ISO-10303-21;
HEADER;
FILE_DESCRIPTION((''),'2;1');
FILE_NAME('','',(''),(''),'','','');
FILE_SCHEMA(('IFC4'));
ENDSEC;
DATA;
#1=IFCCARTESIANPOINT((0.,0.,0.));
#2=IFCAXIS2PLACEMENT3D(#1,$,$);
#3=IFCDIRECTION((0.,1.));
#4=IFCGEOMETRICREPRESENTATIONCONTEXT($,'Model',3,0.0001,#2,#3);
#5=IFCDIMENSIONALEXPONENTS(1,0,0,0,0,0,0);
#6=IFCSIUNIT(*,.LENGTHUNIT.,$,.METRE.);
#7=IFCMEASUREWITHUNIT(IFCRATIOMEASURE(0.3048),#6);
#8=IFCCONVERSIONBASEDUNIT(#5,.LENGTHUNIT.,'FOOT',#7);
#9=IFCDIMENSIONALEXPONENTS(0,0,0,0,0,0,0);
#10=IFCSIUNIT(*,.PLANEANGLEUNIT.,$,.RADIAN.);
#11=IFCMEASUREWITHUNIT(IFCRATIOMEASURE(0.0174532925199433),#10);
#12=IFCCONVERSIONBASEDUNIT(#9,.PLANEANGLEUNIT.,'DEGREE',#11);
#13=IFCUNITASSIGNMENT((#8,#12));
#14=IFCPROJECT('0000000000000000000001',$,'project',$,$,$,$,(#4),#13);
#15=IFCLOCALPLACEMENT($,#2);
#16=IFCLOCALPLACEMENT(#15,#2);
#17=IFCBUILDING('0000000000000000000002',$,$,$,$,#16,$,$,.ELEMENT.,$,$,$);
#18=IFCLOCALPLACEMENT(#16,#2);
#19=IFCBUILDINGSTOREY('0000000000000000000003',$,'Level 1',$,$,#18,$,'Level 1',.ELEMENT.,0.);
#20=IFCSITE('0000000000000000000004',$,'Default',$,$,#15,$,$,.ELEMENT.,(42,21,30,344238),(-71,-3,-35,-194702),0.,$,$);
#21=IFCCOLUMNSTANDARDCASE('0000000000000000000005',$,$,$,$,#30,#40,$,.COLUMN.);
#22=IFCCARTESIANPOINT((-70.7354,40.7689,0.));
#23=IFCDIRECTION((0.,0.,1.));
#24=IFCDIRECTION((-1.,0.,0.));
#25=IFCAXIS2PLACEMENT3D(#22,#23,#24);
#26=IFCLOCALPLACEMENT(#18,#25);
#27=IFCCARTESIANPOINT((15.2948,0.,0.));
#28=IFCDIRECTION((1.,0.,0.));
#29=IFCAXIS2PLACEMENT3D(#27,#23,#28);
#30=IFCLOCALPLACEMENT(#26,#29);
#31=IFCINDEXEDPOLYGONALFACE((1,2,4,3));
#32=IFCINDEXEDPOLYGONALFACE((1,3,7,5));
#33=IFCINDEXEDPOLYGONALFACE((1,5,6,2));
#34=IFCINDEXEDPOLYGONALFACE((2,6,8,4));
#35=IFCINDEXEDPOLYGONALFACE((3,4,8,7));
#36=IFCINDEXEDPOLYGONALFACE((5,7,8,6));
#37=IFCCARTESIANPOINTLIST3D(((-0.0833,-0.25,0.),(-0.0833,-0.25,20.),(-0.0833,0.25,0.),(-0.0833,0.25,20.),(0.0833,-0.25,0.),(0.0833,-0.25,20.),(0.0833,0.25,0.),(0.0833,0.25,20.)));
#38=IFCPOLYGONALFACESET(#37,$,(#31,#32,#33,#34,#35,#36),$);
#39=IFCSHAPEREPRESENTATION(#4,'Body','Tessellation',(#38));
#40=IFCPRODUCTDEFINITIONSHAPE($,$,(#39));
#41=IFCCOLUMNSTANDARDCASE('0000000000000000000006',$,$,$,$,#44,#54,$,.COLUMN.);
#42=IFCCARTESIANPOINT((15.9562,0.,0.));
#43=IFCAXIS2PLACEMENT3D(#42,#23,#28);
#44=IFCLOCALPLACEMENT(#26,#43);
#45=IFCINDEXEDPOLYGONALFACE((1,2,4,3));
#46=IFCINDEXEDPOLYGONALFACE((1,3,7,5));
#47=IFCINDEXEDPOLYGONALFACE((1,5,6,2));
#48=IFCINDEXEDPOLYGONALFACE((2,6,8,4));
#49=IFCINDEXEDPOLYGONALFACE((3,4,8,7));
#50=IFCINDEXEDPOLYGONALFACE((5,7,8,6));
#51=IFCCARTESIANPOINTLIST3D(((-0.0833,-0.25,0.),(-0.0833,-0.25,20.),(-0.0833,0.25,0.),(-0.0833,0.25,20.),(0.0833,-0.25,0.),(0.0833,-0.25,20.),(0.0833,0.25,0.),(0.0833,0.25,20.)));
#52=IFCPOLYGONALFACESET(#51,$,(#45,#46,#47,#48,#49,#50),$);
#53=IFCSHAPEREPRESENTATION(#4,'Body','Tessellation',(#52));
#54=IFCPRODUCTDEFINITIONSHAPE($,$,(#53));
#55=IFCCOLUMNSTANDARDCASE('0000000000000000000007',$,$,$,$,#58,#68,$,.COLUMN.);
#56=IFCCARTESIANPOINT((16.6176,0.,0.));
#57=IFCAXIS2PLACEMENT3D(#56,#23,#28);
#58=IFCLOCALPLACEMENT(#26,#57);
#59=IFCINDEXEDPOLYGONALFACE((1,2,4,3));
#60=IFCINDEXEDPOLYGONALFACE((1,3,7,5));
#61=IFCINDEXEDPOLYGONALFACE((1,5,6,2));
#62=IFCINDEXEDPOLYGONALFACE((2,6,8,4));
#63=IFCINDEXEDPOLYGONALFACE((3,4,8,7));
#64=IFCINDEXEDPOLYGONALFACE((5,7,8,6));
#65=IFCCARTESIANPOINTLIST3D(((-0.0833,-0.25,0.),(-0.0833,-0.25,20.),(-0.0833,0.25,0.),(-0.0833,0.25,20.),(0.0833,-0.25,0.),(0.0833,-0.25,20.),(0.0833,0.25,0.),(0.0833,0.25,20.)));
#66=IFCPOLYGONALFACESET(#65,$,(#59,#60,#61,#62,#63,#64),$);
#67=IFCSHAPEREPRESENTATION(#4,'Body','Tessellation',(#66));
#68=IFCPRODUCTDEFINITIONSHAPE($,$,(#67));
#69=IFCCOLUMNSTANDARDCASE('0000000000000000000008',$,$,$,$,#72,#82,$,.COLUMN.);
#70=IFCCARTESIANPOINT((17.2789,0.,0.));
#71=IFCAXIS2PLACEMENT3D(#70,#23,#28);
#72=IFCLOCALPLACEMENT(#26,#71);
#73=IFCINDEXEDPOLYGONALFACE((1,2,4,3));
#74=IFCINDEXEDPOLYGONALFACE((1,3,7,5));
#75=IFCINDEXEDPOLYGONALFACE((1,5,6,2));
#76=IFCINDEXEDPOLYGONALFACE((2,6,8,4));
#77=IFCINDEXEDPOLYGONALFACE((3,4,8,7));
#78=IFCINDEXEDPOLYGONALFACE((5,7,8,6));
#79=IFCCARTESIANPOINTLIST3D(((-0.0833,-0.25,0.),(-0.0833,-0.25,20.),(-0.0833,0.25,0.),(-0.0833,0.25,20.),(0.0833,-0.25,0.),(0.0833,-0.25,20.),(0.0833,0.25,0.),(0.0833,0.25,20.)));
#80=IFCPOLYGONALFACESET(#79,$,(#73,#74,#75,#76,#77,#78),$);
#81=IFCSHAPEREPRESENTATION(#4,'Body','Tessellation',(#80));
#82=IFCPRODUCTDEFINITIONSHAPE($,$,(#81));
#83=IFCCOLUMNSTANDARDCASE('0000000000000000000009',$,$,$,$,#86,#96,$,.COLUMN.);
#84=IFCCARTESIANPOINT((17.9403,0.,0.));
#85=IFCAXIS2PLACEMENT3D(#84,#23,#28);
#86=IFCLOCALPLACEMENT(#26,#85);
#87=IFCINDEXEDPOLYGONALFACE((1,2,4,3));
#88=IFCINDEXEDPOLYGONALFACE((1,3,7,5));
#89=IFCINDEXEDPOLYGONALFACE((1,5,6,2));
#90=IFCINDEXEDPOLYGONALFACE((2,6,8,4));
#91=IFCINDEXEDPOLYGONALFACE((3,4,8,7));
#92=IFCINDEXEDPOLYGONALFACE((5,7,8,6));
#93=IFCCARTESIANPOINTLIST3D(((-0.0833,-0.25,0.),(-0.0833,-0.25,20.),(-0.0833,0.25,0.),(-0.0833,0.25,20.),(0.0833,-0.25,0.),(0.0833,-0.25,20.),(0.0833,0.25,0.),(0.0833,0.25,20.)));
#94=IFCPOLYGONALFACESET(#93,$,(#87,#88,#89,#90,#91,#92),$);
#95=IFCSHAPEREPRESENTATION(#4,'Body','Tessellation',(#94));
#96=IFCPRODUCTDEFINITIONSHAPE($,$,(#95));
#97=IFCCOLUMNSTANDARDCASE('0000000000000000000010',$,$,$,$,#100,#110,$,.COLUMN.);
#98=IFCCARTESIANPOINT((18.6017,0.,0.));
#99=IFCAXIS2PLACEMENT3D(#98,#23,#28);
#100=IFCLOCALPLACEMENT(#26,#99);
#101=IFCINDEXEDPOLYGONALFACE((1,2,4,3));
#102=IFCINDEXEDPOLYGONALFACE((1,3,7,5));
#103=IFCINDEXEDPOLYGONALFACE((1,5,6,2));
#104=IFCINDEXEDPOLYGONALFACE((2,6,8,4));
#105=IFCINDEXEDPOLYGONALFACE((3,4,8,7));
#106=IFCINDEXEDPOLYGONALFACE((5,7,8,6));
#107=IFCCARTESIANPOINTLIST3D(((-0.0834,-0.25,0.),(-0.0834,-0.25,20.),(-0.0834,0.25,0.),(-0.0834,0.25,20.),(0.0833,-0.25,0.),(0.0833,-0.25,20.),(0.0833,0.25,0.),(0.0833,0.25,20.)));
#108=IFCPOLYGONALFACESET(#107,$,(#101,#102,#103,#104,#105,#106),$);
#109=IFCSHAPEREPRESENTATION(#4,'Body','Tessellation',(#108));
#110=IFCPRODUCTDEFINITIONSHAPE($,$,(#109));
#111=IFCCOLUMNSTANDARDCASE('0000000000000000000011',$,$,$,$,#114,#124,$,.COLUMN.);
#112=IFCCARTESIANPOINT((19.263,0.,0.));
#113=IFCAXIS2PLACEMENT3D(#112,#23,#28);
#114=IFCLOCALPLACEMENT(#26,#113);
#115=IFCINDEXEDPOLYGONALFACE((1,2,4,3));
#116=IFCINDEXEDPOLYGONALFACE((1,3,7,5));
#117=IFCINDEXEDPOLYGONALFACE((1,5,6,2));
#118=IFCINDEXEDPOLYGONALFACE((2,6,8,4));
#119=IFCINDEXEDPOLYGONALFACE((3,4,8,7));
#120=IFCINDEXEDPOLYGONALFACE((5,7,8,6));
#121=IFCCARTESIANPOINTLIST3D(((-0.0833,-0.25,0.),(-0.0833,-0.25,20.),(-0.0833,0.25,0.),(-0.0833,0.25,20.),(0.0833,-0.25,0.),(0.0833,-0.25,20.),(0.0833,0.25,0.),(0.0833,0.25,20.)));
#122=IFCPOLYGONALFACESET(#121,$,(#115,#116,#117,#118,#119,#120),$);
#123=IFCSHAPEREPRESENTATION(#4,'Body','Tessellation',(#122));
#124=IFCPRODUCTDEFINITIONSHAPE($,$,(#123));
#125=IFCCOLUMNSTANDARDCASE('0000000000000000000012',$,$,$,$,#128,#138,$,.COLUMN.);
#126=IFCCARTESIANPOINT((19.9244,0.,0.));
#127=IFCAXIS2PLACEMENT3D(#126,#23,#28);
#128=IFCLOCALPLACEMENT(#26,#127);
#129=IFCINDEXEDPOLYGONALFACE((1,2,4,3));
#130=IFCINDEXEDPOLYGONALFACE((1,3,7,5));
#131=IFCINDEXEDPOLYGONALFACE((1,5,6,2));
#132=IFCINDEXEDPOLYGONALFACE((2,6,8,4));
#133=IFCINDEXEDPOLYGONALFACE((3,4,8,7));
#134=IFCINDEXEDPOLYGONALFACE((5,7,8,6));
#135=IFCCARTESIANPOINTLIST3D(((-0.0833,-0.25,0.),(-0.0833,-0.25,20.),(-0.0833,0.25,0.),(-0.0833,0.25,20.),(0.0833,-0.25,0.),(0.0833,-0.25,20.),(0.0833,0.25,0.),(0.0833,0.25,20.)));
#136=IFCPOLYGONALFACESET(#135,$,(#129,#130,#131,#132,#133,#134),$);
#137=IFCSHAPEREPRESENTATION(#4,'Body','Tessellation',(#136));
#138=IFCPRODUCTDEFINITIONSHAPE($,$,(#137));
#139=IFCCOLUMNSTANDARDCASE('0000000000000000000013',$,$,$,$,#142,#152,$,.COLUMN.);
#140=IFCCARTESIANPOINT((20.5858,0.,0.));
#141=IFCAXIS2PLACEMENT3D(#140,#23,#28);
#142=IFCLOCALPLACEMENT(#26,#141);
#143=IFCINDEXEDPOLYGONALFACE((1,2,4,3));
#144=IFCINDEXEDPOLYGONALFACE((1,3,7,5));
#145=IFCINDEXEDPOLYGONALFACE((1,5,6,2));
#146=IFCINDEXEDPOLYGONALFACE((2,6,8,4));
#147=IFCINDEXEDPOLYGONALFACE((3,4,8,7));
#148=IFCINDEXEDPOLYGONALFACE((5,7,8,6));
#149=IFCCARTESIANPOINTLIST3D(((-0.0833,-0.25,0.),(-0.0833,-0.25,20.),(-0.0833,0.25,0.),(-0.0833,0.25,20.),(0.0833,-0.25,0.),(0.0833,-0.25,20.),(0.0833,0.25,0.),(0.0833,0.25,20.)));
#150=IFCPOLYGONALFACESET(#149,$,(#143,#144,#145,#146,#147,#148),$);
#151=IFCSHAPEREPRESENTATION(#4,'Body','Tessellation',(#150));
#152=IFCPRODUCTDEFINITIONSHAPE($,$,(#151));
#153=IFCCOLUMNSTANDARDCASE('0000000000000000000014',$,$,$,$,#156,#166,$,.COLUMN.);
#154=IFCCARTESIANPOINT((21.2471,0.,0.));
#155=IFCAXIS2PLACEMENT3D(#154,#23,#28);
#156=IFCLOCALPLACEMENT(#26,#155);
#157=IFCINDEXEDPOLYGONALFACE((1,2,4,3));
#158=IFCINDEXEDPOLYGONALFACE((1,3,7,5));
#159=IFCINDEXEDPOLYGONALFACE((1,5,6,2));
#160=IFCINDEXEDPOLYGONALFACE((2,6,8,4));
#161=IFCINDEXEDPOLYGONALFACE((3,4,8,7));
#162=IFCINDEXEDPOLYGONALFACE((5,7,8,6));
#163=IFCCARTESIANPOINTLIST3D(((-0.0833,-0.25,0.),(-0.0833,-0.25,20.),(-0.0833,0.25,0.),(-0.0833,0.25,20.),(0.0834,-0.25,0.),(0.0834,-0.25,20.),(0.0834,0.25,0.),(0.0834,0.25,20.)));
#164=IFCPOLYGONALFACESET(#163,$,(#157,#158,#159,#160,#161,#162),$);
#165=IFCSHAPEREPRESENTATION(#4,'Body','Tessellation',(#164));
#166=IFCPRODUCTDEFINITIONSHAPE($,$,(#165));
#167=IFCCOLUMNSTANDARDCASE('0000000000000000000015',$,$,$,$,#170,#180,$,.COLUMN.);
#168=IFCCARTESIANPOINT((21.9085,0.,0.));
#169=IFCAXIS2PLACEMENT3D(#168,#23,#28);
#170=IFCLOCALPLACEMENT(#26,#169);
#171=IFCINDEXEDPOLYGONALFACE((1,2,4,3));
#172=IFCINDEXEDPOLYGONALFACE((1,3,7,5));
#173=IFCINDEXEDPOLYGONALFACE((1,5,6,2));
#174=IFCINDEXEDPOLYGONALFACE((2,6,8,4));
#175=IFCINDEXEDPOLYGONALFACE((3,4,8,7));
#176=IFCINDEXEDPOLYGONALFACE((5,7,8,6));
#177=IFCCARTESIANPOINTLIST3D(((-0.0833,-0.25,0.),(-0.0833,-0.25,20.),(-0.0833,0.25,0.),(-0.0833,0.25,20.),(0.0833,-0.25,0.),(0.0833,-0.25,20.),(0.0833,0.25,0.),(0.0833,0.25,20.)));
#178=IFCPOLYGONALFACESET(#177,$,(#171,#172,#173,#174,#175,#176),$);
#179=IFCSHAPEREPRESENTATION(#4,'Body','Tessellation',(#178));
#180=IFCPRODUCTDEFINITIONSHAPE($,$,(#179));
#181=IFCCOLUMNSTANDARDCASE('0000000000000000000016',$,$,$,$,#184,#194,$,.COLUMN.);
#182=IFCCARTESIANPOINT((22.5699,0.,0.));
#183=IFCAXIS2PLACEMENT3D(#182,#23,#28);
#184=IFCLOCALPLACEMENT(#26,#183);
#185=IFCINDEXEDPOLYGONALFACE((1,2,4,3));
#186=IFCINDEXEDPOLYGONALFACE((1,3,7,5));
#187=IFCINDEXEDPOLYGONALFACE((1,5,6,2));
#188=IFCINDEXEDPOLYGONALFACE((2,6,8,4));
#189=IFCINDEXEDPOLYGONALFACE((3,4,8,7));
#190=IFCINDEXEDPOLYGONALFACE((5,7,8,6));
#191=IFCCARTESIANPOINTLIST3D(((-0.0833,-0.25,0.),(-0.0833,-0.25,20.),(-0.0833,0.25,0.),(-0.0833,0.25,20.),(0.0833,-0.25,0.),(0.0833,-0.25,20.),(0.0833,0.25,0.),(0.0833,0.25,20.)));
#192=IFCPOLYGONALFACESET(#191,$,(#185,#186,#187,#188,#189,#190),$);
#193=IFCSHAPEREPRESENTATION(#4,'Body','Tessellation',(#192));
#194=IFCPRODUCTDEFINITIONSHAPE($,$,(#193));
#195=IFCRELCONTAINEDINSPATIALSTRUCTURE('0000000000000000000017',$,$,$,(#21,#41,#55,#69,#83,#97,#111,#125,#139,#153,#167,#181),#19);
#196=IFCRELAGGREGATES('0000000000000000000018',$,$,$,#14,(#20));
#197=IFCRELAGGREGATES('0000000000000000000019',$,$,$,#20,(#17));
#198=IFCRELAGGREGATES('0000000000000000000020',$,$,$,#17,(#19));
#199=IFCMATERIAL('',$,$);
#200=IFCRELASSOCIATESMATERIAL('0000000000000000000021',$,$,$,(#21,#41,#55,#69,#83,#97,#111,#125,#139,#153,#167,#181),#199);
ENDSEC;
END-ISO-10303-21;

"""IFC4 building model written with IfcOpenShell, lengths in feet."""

from ifc_helpers import new_model, entity, si_unit, converted_unit, direction, frame, origin, place, context, project, spatial, rectangle, extrude, material, element, save


model = new_model("IFC4")

# Units and contexts
model_context = context("Model", 3, precision=0.0001, world=origin(), true_north=direction((0.0, 1.0)))
ifc_project = project(units=[converted_unit("LENGTHUNIT", "FOOT", entity("IfcRatioMeasure", 0.3048), si_unit("LENGTHUNIT", "METRE"), dimensions=[1, 0, 0, 0, 0, 0, 0]), converted_unit("PLANEANGLEUNIT", "DEGREE", entity("IfcRatioMeasure", 0.0174532925199433), si_unit("PLANEANGLEUNIT", "RADIAN"), dimensions=[0, 0, 0, 0, 0, 0, 0])], contexts=[model_context])

# Site, building, storey
site_placement = place(None, origin())
site = spatial("IfcSite", under=ifc_project, at=site_placement, Name="Default", CompositionType="ELEMENT", RefLatitude=(42, 21, 30, 344238), RefLongitude=(-71, -3, -35, -194702), RefElevation=0.0)
building_placement = place(site_placement, origin())
building = spatial("IfcBuilding", under=site, at=building_placement, CompositionType="ELEMENT")
storey_placement = place(building_placement, origin())
storey = spatial("IfcBuildingStorey", under=building, at=storey_placement, Name="Level 1", LongName="Level 1", CompositionType="ELEMENT", Elevation=0.0)

# Columns
ifc_material_1 = material(Name="")
placement_1 = place(storey_placement, frame((-70.7354, 40.7689, 0.0), z_axis=(0.0, 0.0, 1.0), x_axis=(-1.0, 0.0, 0.0)))
for number, where, z_axis, x_axis in (
    (1, (15.2948, 0.0, 0.0), (0.0, 0.0, 1.0), (1.0, 0.0, 0.0)),
    (2, (15.9562, 0.0, 0.0), (0.0, 0.0, 1.0), (1.0, 0.0, 0.0)),
    (3, (16.6176, 0.0, 0.0), (0.0, 0.0, 1.0), (1.0, 0.0, 0.0)),
    (4, (17.2789, 0.0, 0.0), (0.0, 0.0, 1.0), (1.0, 0.0, 0.0)),
    (5, (17.9403, 0.0, 0.0), (0.0, 0.0, 1.0), (1.0, 0.0, 0.0)),
    (6, (18.6017, 0.0, 0.0), (0.0, 0.0, 1.0), (1.0, 0.0, 0.0)),
    (7, (19.263, 0.0, 0.0), (0.0, 0.0, 1.0), (1.0, 0.0, 0.0)),
    (8, (19.9244, 0.0, 0.0), (0.0, 0.0, 1.0), (1.0, 0.0, 0.0)),
    (9, (20.5858, 0.0, 0.0), (0.0, 0.0, 1.0), (1.0, 0.0, 0.0)),
    (10, (21.2471, 0.0, 0.0), (0.0, 0.0, 1.0), (1.0, 0.0, 0.0)),
    (11, (21.9085, 0.0, 0.0), (0.0, 0.0, 1.0), (1.0, 0.0, 0.0)),
    (12, (22.5699, 0.0, 0.0), (0.0, 0.0, 1.0), (1.0, 0.0, 0.0)),
):
    element("IfcColumnStandardCase", number, at=place(placement_1, frame(where, z_axis=z_axis, x_axis=x_axis)), inside=storey, material=ifc_material_1, PredefinedType="COLUMN", context=model_context, shape_type="SweptSolid", body=[
        extrude(rectangle(XDim=0.1667, YDim=0.5), origin(), (0.0, 0.0, 1.0), 20.0),
    ])

save(model, "model.ifc")
